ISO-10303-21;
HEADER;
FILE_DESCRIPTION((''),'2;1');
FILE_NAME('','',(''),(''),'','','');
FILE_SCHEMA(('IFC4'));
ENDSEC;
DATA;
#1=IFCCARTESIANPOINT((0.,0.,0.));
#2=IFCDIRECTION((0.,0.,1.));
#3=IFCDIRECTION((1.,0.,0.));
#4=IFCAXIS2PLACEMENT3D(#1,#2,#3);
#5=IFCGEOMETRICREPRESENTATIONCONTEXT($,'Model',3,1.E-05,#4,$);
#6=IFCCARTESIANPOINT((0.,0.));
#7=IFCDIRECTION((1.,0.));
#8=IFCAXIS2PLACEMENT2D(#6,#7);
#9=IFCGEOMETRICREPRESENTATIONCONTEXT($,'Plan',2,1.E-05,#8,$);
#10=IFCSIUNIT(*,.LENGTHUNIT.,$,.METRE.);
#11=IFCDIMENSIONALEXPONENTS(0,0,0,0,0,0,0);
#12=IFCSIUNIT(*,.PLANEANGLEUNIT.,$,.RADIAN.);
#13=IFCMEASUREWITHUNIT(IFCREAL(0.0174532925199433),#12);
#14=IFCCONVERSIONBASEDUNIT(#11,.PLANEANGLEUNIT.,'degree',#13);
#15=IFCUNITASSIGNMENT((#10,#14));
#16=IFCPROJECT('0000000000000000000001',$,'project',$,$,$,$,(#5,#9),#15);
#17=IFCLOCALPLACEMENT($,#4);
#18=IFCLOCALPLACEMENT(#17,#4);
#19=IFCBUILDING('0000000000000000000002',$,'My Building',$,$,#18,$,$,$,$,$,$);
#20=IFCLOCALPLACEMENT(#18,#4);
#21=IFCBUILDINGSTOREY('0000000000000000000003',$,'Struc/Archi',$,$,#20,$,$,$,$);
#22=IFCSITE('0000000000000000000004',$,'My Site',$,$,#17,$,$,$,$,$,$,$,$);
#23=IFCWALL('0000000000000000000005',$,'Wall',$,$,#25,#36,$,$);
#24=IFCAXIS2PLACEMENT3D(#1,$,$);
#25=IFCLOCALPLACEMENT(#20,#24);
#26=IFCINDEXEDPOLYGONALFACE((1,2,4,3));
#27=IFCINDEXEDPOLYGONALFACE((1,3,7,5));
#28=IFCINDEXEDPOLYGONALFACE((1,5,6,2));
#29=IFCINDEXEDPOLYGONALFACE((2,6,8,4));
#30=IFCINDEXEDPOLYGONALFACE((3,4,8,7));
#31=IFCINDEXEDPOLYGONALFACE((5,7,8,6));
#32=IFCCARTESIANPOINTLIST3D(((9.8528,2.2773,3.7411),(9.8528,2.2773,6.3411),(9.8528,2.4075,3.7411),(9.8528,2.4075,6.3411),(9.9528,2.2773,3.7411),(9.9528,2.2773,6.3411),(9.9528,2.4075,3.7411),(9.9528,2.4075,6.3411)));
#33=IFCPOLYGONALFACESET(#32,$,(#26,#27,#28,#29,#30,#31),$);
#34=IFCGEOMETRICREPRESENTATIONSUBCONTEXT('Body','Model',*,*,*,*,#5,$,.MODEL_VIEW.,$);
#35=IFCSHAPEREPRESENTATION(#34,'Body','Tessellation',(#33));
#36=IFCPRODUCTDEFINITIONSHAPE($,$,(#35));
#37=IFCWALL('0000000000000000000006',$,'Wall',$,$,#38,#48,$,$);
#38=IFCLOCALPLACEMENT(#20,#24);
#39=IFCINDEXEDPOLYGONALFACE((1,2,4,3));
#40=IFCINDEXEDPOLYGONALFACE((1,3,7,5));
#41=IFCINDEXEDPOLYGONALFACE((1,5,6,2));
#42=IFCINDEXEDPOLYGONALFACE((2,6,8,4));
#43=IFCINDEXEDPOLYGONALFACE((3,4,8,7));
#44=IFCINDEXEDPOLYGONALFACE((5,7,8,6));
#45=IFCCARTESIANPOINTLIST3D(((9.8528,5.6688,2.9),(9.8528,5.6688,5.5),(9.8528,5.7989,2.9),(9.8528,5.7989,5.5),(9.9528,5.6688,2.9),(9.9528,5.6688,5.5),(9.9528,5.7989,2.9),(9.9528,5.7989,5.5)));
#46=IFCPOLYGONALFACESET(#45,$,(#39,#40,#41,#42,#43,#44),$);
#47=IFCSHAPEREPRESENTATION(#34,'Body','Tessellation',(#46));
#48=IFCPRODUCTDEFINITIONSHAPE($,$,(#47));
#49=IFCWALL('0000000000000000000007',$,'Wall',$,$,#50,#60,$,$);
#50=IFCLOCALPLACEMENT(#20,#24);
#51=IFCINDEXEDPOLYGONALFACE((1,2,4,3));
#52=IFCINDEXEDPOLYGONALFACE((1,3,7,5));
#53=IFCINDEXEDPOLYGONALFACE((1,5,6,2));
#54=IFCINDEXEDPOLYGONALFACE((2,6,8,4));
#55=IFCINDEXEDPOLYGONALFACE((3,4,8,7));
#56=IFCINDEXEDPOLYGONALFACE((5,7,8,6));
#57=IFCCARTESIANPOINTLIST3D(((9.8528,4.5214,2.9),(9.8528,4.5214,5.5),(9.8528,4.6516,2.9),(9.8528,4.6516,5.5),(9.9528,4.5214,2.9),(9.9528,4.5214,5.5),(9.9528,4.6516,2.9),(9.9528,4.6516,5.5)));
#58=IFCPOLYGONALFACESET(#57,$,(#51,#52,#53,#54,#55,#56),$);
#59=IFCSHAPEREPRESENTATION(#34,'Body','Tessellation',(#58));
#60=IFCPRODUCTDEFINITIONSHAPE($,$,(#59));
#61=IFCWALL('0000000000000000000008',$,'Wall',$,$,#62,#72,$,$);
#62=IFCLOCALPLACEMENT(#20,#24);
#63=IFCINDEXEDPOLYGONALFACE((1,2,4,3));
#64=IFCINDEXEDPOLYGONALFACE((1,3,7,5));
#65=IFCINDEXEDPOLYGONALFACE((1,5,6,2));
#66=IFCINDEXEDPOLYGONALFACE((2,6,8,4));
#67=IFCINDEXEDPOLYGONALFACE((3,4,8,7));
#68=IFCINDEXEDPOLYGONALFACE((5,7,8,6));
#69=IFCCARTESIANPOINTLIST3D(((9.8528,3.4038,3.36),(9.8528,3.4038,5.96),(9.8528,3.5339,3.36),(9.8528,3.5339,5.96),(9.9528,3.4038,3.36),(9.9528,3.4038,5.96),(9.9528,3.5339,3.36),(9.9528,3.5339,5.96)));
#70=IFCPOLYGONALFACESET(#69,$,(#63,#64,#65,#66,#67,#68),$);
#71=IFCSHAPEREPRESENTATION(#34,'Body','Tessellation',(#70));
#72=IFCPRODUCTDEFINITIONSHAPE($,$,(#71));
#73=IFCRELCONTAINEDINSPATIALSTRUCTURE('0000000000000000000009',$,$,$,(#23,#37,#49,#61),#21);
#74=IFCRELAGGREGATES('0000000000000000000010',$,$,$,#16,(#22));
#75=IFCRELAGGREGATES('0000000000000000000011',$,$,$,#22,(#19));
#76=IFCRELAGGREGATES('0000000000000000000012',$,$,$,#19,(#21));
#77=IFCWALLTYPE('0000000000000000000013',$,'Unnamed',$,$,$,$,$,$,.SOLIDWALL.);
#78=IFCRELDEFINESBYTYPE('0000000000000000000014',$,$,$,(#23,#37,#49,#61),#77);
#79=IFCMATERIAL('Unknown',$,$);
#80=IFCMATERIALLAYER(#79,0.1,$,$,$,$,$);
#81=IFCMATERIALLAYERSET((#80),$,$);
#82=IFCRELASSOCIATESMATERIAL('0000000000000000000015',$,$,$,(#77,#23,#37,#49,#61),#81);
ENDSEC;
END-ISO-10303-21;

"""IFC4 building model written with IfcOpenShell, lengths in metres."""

from ifc_helpers import new_model, entity, si_unit, converted_unit, frame, origin_with_axes, origin_2d_with_axis, place, context, subcontext, project, spatial, line, indexed_curve, outline, extrude, material, layer, layer_set, layer_usage, type_object, element, save


model = new_model("IFC4")

# Units and contexts
model_context = context("Model", 3, precision=1e-05, world=origin_with_axes())
plan_context = context("Plan", 2, precision=1e-05, world=origin_2d_with_axis())
body_context_1 = subcontext(model_context, "Body", "Model", "MODEL_VIEW")
ifc_project = project(units=[si_unit("LENGTHUNIT", "METRE"), converted_unit("PLANEANGLEUNIT", "degree", entity("IfcReal", 0.0174532925199433), si_unit("PLANEANGLEUNIT", "RADIAN"), dimensions=[0, 0, 0, 0, 0, 0, 0])], contexts=[model_context, plan_context])

# Site, building, storey
site_placement = place(None, origin_with_axes())
site = spatial("IfcSite", under=ifc_project, at=site_placement, Name="My Site")
building_placement = place(site_placement, origin_with_axes())
building = spatial("IfcBuilding", under=site, at=building_placement, Name="My Building")
storey_placement = place(building_placement, origin_with_axes())
storey = spatial("IfcBuildingStorey", under=building, at=storey_placement, Name="Struc/Archi")

# Shared definitions
ifc_material = material(Name="Unknown")

# Shared definitions
ifc_layer_1 = layer(ifc_material, 0.1)
ifc_layer_set_1 = layer_set([ifc_layer_1])
wall_type = type_object("IfcWallType", Name="Unnamed", PredefinedType="SOLIDWALL", material=ifc_layer_set_1)

# Walls
ifc_layer_usage_1 = layer_usage(ifc_layer_set_1, "AXIS2", "POSITIVE", 0.0)
wall_1_placement = place(storey_placement, frame((9.8528, 2.4075, 3.7411), z_axis=(0.0, 0.0, 1.0), x_axis=(0.0, -1.0, 0.0)))
element("IfcWall", 1, at=wall_1_placement, inside=storey, type_object=wall_type, material=ifc_layer_usage_1, Name="Wall", context=body_context_1, shape_type="SweptSolid", body=[
    extrude(outline(indexed_curve([(0.0, 0.0), (0.0, 0.1), (0.1301, 0.1), (0.1301, 0.0)], segments=[line(1, 2, 3, 4, 1)])), origin_with_axes(), (0.0, 0.0, 1.0), 2.6),
])
ifc_layer_usage_2 = layer_usage(ifc_layer_set_1, "AXIS2", "POSITIVE", 0.0)
wall_2_placement = place(storey_placement, frame((9.8528, 5.7989, 2.9), z_axis=(0.0, 0.0, 1.0), x_axis=(0.0, -1.0, 0.0)))
element("IfcWall", 2, at=wall_2_placement, inside=storey, type_object=wall_type, material=ifc_layer_usage_2, Name="Wall", context=body_context_1, shape_type="SweptSolid", body=[
    extrude(outline(indexed_curve([(0.0, 0.0), (0.0, 0.1), (0.1301, 0.1), (0.1301, 0.0)], segments=[line(1, 2, 3, 4, 1)])), origin_with_axes(), (0.0, 0.0, 1.0), 2.6),
])
ifc_layer_usage_3 = layer_usage(ifc_layer_set_1, "AXIS2", "POSITIVE", 0.0)
wall_3_placement = place(storey_placement, frame((9.8528, 4.6516, 2.9), z_axis=(0.0, 0.0, 1.0), x_axis=(0.0, -1.0, 0.0)))
element("IfcWall", 3, at=wall_3_placement, inside=storey, type_object=wall_type, material=ifc_layer_usage_3, Name="Wall", context=body_context_1, shape_type="SweptSolid", body=[
    extrude(outline(indexed_curve([(0.0, 0.0), (0.0, 0.1), (0.1301, 0.1), (0.1301, 0.0)], segments=[line(1, 2, 3, 4, 1)])), origin_with_axes(), (0.0, 0.0, 1.0), 2.6),
])
ifc_layer_usage_4 = layer_usage(ifc_layer_set_1, "AXIS2", "POSITIVE", 0.0)
wall_4_placement = place(storey_placement, frame((9.8528, 3.5339, 3.36), z_axis=(0.0, 0.0, 1.0), x_axis=(0.0, -1.0, 0.0)))
element("IfcWall", 4, at=wall_4_placement, inside=storey, type_object=wall_type, material=ifc_layer_usage_4, Name="Wall", context=body_context_1, shape_type="SweptSolid", body=[
    extrude(outline(indexed_curve([(0.0, 0.0), (0.0, 0.1), (0.1301, 0.1), (0.1301, 0.0)], segments=[line(1, 2, 3, 4, 1)])), origin_with_axes(), (0.0, 0.0, 1.0), 2.6),
])

save(model, "model.ifc")
